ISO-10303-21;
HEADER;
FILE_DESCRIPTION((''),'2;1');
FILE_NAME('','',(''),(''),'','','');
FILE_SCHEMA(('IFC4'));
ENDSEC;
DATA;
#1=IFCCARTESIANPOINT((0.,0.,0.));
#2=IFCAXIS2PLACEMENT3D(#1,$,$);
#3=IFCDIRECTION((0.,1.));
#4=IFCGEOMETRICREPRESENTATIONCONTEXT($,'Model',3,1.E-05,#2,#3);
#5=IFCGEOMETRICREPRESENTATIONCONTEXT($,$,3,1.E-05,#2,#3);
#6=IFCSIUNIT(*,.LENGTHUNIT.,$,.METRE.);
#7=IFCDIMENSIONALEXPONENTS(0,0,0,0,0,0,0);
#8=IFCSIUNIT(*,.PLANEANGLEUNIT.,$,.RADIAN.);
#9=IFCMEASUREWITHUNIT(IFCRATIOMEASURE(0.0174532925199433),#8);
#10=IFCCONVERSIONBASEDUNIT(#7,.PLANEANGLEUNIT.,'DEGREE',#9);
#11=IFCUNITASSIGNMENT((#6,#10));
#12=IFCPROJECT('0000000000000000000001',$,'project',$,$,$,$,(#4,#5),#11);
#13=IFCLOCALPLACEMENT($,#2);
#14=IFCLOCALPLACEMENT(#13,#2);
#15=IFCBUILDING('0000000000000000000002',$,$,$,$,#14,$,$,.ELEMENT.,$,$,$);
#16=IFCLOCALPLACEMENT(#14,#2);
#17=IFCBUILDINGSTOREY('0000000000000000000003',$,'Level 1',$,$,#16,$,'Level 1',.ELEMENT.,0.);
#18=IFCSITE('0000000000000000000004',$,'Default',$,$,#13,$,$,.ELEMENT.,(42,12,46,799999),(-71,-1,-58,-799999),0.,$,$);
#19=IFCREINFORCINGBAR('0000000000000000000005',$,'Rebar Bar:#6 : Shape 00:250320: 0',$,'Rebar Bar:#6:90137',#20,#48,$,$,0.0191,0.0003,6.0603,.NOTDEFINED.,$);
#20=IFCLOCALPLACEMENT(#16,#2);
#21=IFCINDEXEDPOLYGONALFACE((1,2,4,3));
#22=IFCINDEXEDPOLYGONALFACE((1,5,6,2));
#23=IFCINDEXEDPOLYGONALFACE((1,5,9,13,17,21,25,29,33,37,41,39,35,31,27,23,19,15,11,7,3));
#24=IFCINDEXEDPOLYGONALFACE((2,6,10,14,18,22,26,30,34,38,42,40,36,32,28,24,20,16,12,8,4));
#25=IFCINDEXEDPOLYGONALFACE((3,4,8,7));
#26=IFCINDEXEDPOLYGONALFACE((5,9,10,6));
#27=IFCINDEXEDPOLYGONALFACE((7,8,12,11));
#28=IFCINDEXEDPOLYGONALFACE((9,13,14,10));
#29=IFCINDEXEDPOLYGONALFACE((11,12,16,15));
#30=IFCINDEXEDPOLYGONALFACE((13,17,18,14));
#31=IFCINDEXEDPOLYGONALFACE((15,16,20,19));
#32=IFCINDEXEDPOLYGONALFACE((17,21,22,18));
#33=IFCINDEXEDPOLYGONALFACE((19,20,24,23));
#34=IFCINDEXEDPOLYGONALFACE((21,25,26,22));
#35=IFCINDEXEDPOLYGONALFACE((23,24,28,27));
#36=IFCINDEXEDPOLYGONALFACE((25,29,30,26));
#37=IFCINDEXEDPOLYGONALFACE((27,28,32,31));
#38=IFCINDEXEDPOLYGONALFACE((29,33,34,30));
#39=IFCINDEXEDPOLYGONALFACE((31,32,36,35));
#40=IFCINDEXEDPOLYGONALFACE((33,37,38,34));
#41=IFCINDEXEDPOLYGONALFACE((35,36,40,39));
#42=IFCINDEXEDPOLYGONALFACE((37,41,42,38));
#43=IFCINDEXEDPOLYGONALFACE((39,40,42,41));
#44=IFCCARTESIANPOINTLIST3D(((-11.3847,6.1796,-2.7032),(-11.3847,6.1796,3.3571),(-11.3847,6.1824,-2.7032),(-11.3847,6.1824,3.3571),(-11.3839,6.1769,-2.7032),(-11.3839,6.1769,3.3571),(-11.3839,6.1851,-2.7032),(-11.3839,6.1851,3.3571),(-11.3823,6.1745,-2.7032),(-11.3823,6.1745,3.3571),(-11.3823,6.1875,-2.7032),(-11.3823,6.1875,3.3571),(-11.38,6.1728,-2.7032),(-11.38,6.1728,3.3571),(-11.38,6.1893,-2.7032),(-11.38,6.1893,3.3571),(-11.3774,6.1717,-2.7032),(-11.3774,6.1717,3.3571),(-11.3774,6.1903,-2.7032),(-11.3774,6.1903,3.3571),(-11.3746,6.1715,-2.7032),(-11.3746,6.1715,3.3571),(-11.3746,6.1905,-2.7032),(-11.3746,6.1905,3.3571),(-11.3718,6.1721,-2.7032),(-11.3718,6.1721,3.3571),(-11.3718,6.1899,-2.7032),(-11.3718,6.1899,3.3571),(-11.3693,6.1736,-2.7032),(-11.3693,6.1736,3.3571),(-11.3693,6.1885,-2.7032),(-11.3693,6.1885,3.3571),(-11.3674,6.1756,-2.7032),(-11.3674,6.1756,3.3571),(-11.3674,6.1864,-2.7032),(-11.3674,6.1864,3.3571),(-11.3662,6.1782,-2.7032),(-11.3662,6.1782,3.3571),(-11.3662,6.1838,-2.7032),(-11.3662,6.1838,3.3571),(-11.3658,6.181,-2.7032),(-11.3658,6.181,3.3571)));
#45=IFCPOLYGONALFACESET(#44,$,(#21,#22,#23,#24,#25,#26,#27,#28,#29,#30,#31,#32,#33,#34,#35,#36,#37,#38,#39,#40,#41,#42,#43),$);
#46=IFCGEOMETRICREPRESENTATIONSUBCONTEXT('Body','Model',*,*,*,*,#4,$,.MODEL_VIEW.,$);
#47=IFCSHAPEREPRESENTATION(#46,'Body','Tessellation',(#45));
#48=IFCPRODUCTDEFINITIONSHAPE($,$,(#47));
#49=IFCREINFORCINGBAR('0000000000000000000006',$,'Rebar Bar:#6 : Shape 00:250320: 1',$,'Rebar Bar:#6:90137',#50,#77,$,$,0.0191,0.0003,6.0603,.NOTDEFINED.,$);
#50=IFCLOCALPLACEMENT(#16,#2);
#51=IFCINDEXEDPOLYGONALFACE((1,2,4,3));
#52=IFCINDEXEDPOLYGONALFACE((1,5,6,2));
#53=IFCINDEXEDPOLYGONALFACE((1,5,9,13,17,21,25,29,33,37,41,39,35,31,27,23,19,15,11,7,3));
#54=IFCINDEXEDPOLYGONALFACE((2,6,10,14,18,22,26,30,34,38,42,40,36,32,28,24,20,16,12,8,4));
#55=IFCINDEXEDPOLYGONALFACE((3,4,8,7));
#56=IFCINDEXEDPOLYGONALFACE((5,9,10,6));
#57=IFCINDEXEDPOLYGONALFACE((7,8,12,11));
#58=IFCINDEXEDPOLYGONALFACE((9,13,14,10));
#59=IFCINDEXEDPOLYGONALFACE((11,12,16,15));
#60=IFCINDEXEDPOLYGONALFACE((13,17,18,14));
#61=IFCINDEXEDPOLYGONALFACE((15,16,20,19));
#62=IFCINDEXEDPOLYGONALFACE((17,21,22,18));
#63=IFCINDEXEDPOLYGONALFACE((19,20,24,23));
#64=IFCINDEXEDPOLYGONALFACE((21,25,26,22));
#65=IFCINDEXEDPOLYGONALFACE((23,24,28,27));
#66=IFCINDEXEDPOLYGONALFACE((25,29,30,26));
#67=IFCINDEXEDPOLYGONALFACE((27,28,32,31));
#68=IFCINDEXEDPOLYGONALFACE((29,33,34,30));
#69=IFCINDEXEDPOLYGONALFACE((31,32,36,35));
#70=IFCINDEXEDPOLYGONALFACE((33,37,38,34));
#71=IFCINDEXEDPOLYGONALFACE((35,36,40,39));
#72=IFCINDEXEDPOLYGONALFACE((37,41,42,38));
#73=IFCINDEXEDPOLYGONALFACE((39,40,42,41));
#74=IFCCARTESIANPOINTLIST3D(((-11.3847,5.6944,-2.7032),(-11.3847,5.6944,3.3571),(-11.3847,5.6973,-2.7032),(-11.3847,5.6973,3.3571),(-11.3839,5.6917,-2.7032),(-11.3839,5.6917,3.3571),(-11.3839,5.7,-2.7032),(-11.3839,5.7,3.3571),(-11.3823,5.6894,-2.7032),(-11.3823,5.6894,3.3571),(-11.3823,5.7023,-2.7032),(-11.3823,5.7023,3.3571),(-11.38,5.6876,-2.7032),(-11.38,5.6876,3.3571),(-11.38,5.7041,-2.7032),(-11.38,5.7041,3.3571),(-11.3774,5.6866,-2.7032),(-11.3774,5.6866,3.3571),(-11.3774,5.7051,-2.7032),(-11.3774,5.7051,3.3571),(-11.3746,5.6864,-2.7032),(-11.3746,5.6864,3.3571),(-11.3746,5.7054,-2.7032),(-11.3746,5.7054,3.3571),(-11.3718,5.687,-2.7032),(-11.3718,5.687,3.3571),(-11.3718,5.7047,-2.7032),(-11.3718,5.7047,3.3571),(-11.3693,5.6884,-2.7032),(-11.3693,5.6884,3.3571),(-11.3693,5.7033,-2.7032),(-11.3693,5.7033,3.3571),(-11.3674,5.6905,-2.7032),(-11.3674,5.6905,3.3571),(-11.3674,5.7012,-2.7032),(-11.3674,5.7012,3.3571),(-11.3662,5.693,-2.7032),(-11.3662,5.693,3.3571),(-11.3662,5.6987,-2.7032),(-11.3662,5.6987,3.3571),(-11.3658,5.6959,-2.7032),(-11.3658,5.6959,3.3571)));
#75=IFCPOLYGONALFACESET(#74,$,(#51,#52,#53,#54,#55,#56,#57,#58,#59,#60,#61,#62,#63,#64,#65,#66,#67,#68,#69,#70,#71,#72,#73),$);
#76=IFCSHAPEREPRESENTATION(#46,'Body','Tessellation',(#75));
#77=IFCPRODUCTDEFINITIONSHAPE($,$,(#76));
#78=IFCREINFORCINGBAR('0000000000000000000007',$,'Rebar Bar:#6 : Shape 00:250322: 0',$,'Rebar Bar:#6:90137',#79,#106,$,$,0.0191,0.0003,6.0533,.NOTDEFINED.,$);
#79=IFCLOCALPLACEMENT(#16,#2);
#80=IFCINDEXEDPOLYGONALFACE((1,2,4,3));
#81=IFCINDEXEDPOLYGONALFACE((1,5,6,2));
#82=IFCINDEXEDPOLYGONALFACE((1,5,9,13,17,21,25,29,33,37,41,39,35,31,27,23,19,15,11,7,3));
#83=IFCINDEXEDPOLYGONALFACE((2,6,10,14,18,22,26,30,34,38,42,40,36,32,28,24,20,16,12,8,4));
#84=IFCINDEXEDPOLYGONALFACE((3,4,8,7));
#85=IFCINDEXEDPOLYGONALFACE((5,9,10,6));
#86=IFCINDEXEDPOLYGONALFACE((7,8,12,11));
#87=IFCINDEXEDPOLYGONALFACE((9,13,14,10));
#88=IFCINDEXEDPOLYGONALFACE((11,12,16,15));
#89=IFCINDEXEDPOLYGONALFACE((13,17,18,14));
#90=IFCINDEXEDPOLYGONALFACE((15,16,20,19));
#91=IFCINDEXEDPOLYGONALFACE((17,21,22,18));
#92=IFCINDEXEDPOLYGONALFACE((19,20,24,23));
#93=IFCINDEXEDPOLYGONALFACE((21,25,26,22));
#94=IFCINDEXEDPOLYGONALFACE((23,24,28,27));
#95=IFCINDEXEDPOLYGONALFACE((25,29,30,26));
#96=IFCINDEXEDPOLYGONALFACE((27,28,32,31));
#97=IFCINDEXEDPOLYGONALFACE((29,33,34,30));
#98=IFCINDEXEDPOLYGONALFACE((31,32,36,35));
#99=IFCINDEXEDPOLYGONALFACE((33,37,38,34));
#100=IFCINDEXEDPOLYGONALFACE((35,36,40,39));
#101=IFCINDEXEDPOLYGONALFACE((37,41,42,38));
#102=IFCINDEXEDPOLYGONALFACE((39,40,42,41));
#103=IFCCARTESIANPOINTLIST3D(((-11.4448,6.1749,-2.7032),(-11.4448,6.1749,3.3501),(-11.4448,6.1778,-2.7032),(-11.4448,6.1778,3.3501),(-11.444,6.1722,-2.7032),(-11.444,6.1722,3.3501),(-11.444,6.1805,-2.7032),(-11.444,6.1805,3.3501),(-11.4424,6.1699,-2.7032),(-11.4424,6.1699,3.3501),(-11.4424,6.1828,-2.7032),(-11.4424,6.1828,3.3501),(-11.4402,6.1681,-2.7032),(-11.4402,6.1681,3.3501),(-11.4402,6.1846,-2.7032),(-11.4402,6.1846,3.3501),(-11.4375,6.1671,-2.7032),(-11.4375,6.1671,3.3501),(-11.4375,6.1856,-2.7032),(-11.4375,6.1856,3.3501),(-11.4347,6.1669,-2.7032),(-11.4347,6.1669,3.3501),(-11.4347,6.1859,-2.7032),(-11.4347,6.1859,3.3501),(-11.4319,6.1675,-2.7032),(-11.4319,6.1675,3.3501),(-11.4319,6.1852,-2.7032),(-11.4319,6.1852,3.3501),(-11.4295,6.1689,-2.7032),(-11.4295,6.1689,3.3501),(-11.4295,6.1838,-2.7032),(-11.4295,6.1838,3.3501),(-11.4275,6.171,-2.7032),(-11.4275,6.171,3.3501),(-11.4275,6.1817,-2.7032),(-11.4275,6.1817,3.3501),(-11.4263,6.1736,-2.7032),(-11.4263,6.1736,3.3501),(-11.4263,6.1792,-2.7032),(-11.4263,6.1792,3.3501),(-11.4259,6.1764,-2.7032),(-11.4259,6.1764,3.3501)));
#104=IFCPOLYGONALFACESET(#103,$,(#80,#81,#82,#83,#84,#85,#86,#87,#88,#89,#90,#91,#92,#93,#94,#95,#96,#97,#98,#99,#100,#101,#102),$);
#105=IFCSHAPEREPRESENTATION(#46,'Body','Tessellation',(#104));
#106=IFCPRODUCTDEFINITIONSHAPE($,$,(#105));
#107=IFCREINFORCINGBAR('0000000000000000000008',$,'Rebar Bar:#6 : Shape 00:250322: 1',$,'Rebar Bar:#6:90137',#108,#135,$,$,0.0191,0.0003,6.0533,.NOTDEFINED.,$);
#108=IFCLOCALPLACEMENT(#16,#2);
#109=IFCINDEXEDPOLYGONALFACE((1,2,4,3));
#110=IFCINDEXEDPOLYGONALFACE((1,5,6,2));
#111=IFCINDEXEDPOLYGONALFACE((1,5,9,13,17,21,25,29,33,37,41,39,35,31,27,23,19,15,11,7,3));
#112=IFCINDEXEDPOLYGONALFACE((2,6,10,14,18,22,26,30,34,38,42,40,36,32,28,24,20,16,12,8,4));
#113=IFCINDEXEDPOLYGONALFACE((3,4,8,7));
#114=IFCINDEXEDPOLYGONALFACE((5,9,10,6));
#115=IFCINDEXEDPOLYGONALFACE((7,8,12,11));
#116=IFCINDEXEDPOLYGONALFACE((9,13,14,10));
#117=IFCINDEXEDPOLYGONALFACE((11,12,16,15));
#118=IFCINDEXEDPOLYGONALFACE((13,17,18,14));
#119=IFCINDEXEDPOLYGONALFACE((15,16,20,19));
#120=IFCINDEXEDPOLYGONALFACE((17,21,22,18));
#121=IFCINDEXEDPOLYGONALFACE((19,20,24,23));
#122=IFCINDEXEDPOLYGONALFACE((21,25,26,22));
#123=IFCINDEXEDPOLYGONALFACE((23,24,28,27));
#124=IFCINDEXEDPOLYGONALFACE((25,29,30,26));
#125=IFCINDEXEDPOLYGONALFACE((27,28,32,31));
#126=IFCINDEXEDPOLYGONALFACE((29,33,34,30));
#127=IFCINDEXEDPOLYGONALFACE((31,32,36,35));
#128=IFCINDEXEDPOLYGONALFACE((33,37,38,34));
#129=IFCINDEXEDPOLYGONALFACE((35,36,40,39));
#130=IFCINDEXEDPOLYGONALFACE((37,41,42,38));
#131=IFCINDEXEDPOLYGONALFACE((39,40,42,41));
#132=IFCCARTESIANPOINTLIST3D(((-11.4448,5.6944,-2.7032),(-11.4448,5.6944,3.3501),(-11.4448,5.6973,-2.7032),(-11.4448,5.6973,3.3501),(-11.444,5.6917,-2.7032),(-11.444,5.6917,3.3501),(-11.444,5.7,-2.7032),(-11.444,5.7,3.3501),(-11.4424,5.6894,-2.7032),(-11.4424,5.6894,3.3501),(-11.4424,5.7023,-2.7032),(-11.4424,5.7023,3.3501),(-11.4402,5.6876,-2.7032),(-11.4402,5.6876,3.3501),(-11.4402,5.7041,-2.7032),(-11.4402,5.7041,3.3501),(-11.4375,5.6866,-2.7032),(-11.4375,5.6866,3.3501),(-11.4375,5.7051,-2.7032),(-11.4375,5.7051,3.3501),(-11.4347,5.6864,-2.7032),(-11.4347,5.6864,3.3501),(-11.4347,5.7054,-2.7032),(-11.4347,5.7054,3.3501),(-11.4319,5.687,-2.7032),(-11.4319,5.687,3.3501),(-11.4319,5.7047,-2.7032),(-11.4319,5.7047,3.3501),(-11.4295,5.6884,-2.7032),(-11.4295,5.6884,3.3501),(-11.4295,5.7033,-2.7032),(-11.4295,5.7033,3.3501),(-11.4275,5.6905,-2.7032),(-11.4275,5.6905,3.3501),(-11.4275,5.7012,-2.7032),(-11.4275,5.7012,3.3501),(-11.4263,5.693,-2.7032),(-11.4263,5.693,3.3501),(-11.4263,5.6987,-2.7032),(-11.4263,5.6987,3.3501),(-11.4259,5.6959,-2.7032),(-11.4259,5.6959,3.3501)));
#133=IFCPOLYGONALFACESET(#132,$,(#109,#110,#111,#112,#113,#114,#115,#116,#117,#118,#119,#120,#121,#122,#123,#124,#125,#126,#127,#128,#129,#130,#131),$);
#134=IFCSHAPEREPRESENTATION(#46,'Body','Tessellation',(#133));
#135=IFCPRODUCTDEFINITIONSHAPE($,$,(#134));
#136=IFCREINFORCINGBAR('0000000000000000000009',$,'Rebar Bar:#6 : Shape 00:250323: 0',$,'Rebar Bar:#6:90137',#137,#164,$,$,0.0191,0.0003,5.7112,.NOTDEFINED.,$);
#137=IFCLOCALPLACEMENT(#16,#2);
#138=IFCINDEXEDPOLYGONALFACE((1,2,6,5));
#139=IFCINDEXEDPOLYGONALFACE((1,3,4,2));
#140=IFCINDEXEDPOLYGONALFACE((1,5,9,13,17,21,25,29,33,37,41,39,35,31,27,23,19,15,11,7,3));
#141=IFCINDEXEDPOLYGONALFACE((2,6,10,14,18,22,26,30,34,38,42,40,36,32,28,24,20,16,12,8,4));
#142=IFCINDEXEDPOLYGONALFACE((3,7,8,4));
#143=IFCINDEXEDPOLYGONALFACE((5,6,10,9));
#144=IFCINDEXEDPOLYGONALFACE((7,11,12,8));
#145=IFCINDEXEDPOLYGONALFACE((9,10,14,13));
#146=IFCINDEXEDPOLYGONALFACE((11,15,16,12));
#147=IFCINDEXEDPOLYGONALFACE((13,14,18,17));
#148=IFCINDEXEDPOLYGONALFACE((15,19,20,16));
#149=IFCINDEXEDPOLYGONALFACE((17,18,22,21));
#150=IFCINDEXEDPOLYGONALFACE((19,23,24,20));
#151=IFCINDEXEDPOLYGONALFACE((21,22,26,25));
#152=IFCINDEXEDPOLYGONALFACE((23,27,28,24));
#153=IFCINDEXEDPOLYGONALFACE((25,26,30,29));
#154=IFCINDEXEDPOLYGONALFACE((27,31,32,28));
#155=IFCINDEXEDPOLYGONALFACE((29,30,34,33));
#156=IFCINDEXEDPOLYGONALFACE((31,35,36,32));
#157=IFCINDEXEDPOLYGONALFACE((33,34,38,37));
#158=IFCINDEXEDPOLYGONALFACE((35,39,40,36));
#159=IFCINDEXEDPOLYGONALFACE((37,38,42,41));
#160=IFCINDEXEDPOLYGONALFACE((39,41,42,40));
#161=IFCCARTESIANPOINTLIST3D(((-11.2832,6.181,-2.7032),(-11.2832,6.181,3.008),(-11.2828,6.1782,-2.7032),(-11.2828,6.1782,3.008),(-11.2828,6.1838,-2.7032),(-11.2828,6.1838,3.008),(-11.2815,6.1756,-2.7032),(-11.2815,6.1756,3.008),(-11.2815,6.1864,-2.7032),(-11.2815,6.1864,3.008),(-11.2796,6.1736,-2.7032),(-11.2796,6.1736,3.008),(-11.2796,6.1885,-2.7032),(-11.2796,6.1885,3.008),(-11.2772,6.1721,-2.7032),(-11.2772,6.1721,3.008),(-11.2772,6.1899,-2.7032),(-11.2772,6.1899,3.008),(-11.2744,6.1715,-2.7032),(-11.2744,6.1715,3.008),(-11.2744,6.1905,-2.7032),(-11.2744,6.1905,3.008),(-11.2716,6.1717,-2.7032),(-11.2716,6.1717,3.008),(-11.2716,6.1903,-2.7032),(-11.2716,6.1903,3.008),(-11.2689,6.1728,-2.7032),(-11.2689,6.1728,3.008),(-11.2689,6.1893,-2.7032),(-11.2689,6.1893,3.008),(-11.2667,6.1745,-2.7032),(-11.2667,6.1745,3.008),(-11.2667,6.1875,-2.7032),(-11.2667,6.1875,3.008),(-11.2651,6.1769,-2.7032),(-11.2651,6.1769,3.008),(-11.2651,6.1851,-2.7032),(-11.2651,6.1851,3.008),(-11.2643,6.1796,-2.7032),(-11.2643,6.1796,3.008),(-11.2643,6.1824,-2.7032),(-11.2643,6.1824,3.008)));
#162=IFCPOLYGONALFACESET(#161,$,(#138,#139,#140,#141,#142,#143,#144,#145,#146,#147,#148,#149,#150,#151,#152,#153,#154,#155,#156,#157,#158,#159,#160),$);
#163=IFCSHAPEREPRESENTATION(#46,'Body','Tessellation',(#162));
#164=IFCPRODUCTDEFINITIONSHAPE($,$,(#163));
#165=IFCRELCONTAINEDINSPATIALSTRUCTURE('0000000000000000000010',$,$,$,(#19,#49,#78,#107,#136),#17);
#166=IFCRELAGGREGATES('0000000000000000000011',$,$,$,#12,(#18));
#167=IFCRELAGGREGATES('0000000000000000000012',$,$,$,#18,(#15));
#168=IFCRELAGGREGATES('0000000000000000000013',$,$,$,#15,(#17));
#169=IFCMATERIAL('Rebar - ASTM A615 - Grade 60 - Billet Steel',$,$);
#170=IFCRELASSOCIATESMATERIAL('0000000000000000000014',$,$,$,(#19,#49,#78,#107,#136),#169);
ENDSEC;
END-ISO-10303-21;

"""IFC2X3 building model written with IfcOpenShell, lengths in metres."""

from ifc_helpers import new_model, entity, si_unit, converted_unit, direction, origin, place, context, subcontext, project, spatial, material, element, save


model = new_model("IFC2X3")

# Units and contexts
model_context = context("Model", 3, precision=1e-05, world=origin(), true_north=direction((0.0, 1.0)))
context_of_model = context(None, 3, precision=1e-05, world=origin(), true_north=direction((0.0, 1.0)))
body_context = subcontext(model_context, "Body", "Model", "MODEL_VIEW")
ifc_project = project(units=[si_unit("LENGTHUNIT", "METRE"), converted_unit("PLANEANGLEUNIT", "DEGREE", entity("IfcRatioMeasure", 0.0174532925199433), si_unit("PLANEANGLEUNIT", "RADIAN"), dimensions=[0, 0, 0, 0, 0, 0, 0])], contexts=[model_context, context_of_model])

# Site, building, storey
site_placement = place(None, origin())
site = spatial("IfcSite", under=ifc_project, at=site_placement, Name="Default", CompositionType="ELEMENT", RefLatitude=(42, 12, 46, 799999), RefLongitude=(-71, -1, -58, -799999), RefElevation=0.0)
building_placement = place(site_placement, origin())
building = spatial("IfcBuilding", under=site, at=building_placement, CompositionType="ELEMENT")
storey_placement = place(building_placement, origin())
storey = spatial("IfcBuildingStorey", under=building, at=storey_placement, Name="Level 1", LongName="Level 1", CompositionType="ELEMENT", Elevation=0.0)

# Reinforcing bars
ifc_material = material(Name="Rebar - ASTM A615 - Grade 60 - Billet Steel")
reinforcing_bar_1_placement = place(storey_placement, origin())
element("IfcReinforcingBar", 1, at=reinforcing_bar_1_placement, inside=storey, material=ifc_material, Name="Rebar Bar:#6 : Shape 00:250320: 0", ObjectType="Rebar Bar:#6:90137", BarLength=6.0603, BarRole="NOTDEFINED", CrossSectionArea=0.0003, NominalDiameter=0.0191, context=body_context, shape_type="AdvancedSweptSolid", body=[
    entity("IfcSweptDiskSolid", entity("IfcCompositeCurve", [entity("IfcCompositeCurveSegment", "CONTINUOUS", True, entity("IfcPolyline", [entity("IfcCartesianPoint", [-11.3753, 6.181, -2.7032]), entity("IfcCartesianPoint", [-11.3753, 6.181, 3.3571])]))], False), 0.0095, None, 0.0, 1.0),
])
reinforcing_bar_2_placement = place(storey_placement, origin())
element("IfcReinforcingBar", 2, at=reinforcing_bar_2_placement, inside=storey, material=ifc_material, Name="Rebar Bar:#6 : Shape 00:250320: 1", ObjectType="Rebar Bar:#6:90137", BarLength=6.0603, BarRole="NOTDEFINED", CrossSectionArea=0.0003, NominalDiameter=0.0191, context=body_context, shape_type="AdvancedSweptSolid", body=[
    entity("IfcSweptDiskSolid", entity("IfcCompositeCurve", [entity("IfcCompositeCurveSegment", "CONTINUOUS", True, entity("IfcPolyline", [entity("IfcCartesianPoint", [-11.3753, 5.6959, -2.7032]), entity("IfcCartesianPoint", [-11.3753, 5.6959, 3.3571])]))], False), 0.0095, None, 0.0, 1.0),
])
reinforcing_bar_3_placement = place(storey_placement, origin())
element("IfcReinforcingBar", 3, at=reinforcing_bar_3_placement, inside=storey, material=ifc_material, Name="Rebar Bar:#6 : Shape 00:250322: 0", ObjectType="Rebar Bar:#6:90137", BarLength=6.0533, BarRole="NOTDEFINED", CrossSectionArea=0.0003, NominalDiameter=0.0191, context=body_context, shape_type="AdvancedSweptSolid", body=[
    entity("IfcSweptDiskSolid", entity("IfcCompositeCurve", [entity("IfcCompositeCurveSegment", "CONTINUOUS", True, entity("IfcPolyline", [entity("IfcCartesianPoint", [-11.4354, 6.1764, -2.7032]), entity("IfcCartesianPoint", [-11.4354, 6.1764, 3.3501])]))], False), 0.0095, None, 0.0, 1.0),
])
reinforcing_bar_4_placement = place(storey_placement, origin())
element("IfcReinforcingBar", 4, at=reinforcing_bar_4_placement, inside=storey, material=ifc_material, Name="Rebar Bar:#6 : Shape 00:250322: 1", ObjectType="Rebar Bar:#6:90137", BarLength=6.0533, BarRole="NOTDEFINED", CrossSectionArea=0.0003, NominalDiameter=0.0191, context=body_context, shape_type="AdvancedSweptSolid", body=[
    entity("IfcSweptDiskSolid", entity("IfcCompositeCurve", [entity("IfcCompositeCurveSegment", "CONTINUOUS", True, entity("IfcPolyline", [entity("IfcCartesianPoint", [-11.4354, 5.6959, -2.7032]), entity("IfcCartesianPoint", [-11.4354, 5.6959, 3.3501])]))], False), 0.0095, None, 0.0, 1.0),
])
reinforcing_bar_5_placement = place(storey_placement, origin())
element("IfcReinforcingBar", 5, at=reinforcing_bar_5_placement, inside=storey, material=ifc_material, Name="Rebar Bar:#6 : Shape 00:250323: 0", ObjectType="Rebar Bar:#6:90137", BarLength=5.7112, BarRole="NOTDEFINED", CrossSectionArea=0.0003, NominalDiameter=0.0191, context=body_context, shape_type="AdvancedSweptSolid", body=[
    entity("IfcSweptDiskSolid", entity("IfcCompositeCurve", [entity("IfcCompositeCurveSegment", "CONTINUOUS", True, entity("IfcPolyline", [entity("IfcCartesianPoint", [-11.2737, 6.181, 3.008]), entity("IfcCartesianPoint", [-11.2737, 6.181, -2.7032])]))], False), 0.0095, None, 0.0, 1.0),
])

save(model, "model.ifc")
